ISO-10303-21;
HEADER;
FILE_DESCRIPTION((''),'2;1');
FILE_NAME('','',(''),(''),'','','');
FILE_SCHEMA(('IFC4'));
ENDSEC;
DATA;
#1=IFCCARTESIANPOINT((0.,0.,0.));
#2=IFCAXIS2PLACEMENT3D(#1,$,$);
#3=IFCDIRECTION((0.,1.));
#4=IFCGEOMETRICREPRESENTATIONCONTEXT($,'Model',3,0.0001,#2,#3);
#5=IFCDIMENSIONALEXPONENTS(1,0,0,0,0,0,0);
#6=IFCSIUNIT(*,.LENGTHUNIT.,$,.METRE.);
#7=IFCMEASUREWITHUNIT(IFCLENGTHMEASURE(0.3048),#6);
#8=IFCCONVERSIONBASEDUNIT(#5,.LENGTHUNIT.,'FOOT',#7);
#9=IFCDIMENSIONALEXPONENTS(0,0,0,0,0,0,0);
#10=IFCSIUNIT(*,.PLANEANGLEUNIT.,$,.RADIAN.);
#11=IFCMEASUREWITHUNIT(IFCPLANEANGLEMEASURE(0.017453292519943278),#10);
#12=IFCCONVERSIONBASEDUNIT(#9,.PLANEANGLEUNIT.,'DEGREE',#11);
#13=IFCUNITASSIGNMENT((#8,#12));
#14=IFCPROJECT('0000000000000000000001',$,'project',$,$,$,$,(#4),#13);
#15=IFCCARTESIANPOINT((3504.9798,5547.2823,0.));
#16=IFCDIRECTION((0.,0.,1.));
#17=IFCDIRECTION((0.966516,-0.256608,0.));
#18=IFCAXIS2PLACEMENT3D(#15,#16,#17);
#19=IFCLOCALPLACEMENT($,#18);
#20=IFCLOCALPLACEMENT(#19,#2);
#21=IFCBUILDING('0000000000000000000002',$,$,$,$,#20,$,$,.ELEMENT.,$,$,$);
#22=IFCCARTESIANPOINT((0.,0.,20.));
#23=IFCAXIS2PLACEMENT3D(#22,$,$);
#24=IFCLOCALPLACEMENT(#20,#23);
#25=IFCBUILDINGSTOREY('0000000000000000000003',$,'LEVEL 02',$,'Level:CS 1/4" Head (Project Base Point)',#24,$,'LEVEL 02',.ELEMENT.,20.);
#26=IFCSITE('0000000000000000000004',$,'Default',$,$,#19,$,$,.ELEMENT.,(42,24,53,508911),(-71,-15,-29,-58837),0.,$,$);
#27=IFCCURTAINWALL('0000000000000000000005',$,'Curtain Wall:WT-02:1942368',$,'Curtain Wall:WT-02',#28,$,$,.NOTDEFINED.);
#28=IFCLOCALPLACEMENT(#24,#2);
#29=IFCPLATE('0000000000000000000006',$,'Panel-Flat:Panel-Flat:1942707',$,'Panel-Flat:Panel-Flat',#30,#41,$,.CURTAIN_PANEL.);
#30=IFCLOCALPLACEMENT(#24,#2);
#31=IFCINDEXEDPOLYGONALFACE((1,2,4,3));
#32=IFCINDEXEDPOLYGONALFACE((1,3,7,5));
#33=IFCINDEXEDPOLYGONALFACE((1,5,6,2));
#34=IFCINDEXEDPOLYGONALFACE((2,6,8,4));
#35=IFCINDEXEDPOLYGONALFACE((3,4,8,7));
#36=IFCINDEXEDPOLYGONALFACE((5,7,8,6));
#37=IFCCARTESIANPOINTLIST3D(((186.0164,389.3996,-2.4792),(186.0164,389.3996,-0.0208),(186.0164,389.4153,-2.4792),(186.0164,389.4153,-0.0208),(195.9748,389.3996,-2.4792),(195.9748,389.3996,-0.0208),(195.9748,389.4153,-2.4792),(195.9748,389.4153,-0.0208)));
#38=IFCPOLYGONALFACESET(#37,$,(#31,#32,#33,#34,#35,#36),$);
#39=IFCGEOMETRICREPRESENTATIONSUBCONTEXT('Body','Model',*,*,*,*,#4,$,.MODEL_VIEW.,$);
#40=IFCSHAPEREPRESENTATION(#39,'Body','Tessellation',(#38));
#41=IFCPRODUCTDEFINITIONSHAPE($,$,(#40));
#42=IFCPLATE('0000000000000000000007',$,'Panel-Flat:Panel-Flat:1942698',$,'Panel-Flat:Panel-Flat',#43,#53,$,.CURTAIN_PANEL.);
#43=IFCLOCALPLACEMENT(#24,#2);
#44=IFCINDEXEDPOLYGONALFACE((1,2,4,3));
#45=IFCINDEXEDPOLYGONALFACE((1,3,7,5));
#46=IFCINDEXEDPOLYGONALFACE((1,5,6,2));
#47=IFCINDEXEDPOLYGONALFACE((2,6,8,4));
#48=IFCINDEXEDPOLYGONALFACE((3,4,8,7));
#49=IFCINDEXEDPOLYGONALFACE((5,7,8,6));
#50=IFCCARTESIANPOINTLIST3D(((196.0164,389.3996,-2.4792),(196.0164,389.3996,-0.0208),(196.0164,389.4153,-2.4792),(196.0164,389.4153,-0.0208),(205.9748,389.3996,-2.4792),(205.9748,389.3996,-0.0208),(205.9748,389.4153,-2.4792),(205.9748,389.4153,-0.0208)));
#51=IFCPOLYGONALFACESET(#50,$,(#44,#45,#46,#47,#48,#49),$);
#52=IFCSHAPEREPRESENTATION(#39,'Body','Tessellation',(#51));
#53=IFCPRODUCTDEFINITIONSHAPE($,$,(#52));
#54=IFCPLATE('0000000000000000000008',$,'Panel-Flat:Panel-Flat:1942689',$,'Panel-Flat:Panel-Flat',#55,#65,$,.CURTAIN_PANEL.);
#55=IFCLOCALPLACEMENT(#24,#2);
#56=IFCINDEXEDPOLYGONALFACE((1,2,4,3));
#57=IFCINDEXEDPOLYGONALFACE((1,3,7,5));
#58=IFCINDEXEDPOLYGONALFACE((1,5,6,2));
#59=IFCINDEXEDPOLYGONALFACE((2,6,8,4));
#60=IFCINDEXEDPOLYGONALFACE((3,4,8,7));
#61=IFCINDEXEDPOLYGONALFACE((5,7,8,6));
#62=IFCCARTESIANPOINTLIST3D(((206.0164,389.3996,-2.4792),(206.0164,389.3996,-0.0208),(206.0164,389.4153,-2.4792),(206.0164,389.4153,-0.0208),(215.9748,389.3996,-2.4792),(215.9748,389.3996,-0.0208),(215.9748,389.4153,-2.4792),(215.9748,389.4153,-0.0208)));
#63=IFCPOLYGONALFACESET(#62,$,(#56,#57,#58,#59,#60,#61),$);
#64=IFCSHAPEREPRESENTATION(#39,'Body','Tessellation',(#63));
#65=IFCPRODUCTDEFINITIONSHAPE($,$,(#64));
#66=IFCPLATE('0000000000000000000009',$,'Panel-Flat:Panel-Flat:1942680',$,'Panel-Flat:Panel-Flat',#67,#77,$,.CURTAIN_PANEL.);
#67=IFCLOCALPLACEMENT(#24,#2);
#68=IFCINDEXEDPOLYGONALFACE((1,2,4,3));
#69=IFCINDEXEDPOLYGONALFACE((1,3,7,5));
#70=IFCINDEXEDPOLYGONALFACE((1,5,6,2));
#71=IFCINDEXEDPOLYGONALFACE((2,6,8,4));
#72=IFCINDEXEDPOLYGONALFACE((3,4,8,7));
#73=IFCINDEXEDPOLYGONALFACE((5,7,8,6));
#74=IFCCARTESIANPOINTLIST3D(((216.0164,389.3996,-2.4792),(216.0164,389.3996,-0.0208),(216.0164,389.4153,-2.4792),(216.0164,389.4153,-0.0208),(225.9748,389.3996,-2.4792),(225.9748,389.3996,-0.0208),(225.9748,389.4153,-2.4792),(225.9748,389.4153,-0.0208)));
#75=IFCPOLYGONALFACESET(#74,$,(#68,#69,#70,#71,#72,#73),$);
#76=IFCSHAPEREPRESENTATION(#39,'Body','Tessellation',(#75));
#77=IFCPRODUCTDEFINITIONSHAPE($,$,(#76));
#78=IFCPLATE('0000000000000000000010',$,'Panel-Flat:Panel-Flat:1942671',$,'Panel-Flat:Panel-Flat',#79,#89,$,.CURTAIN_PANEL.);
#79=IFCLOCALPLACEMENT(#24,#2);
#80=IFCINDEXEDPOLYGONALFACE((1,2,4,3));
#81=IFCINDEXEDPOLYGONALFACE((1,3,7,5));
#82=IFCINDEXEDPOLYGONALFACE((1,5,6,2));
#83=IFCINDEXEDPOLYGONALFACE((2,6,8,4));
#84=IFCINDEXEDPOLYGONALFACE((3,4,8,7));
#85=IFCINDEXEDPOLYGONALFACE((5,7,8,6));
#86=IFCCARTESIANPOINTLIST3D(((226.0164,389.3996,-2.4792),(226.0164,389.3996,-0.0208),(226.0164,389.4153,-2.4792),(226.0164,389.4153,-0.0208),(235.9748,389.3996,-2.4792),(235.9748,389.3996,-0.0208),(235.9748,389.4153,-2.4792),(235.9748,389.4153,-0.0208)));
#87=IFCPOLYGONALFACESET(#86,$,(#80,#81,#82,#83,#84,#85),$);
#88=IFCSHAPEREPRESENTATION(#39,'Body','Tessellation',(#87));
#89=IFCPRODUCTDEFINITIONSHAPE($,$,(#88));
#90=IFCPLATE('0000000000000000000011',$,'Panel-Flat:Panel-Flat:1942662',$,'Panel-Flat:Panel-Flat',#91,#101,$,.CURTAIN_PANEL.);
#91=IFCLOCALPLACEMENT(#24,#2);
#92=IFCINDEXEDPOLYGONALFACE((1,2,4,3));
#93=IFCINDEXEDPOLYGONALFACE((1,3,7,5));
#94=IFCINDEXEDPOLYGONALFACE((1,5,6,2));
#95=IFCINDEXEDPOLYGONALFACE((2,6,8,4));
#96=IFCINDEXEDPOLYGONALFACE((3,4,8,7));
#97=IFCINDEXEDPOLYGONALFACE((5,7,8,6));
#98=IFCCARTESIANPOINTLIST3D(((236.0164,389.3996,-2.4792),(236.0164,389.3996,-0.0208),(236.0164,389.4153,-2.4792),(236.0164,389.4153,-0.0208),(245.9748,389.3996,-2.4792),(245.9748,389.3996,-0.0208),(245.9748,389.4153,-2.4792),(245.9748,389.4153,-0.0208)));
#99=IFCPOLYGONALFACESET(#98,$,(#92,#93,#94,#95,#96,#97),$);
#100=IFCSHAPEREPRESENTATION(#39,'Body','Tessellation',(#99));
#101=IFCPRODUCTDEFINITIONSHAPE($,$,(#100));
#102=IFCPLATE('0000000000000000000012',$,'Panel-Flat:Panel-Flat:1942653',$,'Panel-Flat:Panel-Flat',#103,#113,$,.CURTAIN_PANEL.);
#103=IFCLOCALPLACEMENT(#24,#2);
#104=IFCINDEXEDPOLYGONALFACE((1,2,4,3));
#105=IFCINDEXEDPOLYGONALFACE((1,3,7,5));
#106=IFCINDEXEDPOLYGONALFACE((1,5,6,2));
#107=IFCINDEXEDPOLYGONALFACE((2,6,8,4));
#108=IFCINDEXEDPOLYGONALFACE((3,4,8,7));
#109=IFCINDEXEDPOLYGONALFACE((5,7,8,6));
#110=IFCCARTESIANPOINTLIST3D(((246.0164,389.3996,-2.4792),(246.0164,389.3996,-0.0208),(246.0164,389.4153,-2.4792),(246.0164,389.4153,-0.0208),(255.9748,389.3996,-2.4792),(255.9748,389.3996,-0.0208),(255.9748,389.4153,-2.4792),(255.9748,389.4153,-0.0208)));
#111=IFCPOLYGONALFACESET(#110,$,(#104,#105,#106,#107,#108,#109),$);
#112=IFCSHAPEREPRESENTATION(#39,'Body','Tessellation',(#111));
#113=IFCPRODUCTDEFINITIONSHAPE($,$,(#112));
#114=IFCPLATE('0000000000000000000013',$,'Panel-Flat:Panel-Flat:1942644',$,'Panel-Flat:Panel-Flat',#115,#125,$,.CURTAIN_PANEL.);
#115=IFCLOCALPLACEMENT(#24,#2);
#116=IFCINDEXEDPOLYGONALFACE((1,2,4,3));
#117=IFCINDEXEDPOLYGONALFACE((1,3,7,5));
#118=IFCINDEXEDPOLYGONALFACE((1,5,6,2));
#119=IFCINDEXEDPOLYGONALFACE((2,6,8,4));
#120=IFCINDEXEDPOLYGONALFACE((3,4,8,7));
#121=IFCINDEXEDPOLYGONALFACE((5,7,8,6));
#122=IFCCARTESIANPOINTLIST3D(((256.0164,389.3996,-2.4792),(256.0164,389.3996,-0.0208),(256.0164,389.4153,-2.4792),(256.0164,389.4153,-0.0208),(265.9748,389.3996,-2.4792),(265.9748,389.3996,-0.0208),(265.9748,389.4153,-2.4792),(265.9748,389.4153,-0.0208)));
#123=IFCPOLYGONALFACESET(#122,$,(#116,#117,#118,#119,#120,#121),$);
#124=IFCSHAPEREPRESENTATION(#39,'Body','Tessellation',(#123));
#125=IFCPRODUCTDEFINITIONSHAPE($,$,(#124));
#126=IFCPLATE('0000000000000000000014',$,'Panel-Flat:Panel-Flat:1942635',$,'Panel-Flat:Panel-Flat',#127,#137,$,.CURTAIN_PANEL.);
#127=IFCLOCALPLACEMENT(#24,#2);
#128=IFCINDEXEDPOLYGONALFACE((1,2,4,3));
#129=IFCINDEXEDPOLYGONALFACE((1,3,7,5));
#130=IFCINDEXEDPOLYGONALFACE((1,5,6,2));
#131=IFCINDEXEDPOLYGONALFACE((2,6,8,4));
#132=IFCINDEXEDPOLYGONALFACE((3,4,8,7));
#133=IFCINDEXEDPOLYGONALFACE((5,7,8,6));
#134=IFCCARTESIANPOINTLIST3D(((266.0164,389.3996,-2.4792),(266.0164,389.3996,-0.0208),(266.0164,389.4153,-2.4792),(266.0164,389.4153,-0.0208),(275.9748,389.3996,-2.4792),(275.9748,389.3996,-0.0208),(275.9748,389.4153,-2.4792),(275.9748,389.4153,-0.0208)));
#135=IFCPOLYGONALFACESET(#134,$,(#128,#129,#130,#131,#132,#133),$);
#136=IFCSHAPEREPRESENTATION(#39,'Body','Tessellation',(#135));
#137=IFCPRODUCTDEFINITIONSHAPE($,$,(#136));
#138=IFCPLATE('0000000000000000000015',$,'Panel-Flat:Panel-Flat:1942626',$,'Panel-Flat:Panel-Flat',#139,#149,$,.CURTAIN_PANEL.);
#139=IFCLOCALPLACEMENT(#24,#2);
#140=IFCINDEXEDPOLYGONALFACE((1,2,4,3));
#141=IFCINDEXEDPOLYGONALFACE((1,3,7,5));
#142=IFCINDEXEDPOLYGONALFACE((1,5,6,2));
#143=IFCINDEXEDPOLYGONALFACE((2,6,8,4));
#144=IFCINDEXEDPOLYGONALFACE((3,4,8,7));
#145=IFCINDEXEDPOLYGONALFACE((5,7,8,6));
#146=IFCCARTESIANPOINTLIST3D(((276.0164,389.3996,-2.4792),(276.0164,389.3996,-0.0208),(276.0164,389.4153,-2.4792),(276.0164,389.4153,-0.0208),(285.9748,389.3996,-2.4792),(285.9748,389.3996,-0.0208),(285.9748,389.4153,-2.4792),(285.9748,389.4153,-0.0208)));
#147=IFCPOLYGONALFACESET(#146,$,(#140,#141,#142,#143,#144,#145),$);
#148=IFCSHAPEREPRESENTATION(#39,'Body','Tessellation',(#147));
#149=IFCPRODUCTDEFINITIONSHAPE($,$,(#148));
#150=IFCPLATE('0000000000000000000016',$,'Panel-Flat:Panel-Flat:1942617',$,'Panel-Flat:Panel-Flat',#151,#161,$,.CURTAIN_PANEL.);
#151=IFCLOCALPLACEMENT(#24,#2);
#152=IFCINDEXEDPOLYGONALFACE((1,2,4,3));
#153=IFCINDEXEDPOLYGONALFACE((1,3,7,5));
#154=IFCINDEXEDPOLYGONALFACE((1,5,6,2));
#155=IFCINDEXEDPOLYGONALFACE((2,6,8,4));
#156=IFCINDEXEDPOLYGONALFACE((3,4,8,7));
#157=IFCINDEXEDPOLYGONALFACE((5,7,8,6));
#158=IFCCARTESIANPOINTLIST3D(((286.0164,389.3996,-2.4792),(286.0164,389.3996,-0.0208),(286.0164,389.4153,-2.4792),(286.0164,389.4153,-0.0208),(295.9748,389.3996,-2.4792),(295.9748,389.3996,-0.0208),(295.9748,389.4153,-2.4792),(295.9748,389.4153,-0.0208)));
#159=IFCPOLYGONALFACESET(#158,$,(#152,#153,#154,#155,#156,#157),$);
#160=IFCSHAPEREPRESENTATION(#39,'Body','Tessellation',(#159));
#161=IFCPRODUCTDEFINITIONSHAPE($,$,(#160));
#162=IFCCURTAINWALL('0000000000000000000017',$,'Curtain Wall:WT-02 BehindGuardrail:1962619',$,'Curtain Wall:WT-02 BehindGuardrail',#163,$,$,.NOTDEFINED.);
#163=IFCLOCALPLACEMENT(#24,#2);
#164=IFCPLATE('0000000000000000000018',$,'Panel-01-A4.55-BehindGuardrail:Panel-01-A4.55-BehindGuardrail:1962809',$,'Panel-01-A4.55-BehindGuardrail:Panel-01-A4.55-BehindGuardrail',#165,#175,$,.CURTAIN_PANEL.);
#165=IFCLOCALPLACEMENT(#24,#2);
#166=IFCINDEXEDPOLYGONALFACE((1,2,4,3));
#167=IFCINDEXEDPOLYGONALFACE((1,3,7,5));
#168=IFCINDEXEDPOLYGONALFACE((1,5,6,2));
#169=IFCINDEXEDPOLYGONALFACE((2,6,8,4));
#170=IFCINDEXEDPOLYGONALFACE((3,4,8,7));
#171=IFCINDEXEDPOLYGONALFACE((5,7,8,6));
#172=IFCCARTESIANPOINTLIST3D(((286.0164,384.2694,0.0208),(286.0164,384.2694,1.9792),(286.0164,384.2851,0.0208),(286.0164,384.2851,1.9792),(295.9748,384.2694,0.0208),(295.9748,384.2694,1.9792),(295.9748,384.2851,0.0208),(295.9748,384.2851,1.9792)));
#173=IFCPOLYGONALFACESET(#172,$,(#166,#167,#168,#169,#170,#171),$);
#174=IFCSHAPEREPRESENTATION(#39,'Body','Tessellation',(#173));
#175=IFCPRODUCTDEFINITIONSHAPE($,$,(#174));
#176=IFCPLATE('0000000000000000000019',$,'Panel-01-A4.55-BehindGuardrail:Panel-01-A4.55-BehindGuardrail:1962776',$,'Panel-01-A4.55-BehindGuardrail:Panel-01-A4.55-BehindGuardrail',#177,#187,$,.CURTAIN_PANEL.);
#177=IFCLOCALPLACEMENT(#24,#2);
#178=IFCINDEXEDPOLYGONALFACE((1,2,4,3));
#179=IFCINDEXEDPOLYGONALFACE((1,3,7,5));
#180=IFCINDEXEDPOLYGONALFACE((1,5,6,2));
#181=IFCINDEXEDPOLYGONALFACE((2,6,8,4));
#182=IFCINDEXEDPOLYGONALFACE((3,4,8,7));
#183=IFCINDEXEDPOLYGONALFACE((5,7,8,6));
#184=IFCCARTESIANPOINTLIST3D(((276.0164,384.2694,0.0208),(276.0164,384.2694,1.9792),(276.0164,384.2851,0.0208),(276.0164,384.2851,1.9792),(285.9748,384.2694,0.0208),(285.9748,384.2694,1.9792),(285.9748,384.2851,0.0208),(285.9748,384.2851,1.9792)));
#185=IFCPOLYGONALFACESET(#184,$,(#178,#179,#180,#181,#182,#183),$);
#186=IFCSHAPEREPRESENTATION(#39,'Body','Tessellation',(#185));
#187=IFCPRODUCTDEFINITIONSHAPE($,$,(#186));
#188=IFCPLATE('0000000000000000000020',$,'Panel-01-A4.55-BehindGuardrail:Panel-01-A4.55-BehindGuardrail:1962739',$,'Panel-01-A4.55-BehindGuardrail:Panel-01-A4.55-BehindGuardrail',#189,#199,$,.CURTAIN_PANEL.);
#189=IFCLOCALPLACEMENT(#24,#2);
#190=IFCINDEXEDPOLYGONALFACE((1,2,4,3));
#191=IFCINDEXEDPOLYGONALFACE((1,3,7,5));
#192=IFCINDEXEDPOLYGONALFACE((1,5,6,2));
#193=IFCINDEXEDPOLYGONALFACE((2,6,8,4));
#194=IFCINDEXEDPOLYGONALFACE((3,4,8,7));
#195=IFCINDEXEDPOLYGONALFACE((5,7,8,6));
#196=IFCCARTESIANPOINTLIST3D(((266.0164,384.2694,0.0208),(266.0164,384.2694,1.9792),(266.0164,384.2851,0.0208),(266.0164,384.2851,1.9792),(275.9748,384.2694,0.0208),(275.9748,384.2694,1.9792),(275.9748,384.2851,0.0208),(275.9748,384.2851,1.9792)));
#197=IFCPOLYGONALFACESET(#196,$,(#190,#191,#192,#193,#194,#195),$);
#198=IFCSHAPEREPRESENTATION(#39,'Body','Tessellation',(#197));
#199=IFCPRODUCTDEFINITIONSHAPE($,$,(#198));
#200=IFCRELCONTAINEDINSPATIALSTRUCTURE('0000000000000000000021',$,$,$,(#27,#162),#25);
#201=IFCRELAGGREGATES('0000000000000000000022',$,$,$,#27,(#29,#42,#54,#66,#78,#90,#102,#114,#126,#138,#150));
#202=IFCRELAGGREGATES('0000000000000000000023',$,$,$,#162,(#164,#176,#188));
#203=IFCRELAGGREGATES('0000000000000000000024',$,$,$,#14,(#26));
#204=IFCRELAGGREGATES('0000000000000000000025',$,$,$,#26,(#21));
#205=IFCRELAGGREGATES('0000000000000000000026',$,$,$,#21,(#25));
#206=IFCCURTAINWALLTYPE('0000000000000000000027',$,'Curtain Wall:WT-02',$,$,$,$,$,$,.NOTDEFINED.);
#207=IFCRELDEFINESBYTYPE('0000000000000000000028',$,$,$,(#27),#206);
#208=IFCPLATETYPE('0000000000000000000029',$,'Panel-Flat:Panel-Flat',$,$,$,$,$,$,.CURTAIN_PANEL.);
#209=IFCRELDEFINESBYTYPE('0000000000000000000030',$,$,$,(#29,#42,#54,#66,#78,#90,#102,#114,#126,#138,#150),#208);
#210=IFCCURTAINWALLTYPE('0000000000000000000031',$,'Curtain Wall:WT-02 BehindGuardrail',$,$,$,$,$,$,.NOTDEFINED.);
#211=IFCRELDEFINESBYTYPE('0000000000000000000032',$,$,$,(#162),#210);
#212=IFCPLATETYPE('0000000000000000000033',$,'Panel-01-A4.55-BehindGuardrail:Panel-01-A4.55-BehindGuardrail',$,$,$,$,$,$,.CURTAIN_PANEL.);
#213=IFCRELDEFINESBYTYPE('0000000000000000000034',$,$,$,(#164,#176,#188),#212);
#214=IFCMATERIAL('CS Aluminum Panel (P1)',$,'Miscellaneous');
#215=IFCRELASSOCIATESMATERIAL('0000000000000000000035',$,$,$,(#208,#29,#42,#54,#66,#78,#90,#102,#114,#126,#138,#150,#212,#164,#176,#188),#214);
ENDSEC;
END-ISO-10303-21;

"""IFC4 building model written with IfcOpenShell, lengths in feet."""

from ifc_helpers import new_model, entity, si_unit, converted_unit, direction, frame, origin, place, context, subcontext, project, spatial, indexed_curve, outline, extrude, source, transform, mapped, material, type_object, type_shapes, element, aggregate, save


model = new_model("IFC4")

# Units and contexts
model_context = context("Model", 3, precision=0.0001, world=origin(), true_north=direction((0.0, 1.0)))
body_context = subcontext(model_context, "Body", "Model", "MODEL_VIEW")
ifc_project = project(units=[converted_unit("LENGTHUNIT", "FOOT", entity("IfcLengthMeasure", 0.3048), si_unit("LENGTHUNIT", "METRE"), dimensions=[1, 0, 0, 0, 0, 0, 0]), converted_unit("PLANEANGLEUNIT", "DEGREE", entity("IfcPlaneAngleMeasure", 0.017453292519943278), si_unit("PLANEANGLEUNIT", "RADIAN"), dimensions=[0, 0, 0, 0, 0, 0, 0])], contexts=[model_context])

# Site, building, storey
site_placement = place(None, frame((3504.9798, 5547.2823, 0.0), z_axis=(0.0, 0.0, 1.0), x_axis=(0.966516, -0.256608, 0.0)))
site = spatial("IfcSite", under=ifc_project, at=site_placement, Name="Default", CompositionType="ELEMENT", RefLatitude=(42, 24, 53, 508911), RefLongitude=(-71, -15, -29, -58837), RefElevation=0.0)
building_placement = place(site_placement, origin())
building = spatial("IfcBuilding", under=site, at=building_placement, CompositionType="ELEMENT")
storey_placement = place(building_placement, frame((0.0, 0.0, 20.0)))
storey = spatial("IfcBuildingStorey", under=building, at=storey_placement, Name="LEVEL 02", ObjectType="Level:CS 1/4\" Head (Project Base Point)", LongName="LEVEL 02", CompositionType="ELEMENT", Elevation=20.0)

# Curtain walls, plates
curtain_wall_type_1 = type_object("IfcCurtainWallType", Name="Curtain Wall:WT-02", PredefinedType="NOTDEFINED")
curtain_wall_1_placement = place(storey_placement, frame((0.0, 0.0, -20.0)))
curtain_wall_1 = element("IfcCurtainWall", 1, at=curtain_wall_1_placement, inside=storey, type_object=curtain_wall_type_1, Name="Curtain Wall:WT-02:1942368", ObjectType="Curtain Wall:WT-02", PredefinedType="NOTDEFINED")
ifc_material_1 = material(Name="CS Aluminum Panel (P1)", Category="Miscellaneous")
plate_type_1 = type_object("IfcPlateType", Name="Panel-Flat:Panel-Flat", PredefinedType="CURTAIN_PANEL", material=ifc_material_1)
shared_shape_1 = source(origin(), body_context, "Body", "SweptSolid", [
    extrude(outline(indexed_curve([(-0.0078, -4.9792), (0.0078, -4.9792), (0.0078, 4.9792), (-0.0078, 4.9792), (-0.0078, -4.9792)], self_intersect=False)), frame((0.0, -0.0078, 0.0208), z_axis=(0.0, 0.0, 1.0), x_axis=(0.0, -1.0, 0.0)), (0.0, 0.0, 1.0), 2.4583),
])
type_shapes(plate_type_1, [shared_shape_1])
plate_1_placement = place(curtain_wall_1_placement, frame((190.9956, 389.4153, 17.5)))
plate_1 = element("IfcPlate", 2, at=plate_1_placement, type_object=plate_type_1, material=ifc_material_1, Name="Panel-Flat:Panel-Flat:1942707", ObjectType="Panel-Flat:Panel-Flat", PredefinedType="CURTAIN_PANEL", context=body_context, shape_type="MappedRepresentation", body=[
    mapped(shared_shape_1, transform((0.0, 0.0, 0.0), scale=1.0)),
])
plate_2_placement = place(curtain_wall_1_placement, frame((200.9956, 389.4153, 17.5)))
plate_2 = element("IfcPlate", 3, at=plate_2_placement, type_object=plate_type_1, material=ifc_material_1, Name="Panel-Flat:Panel-Flat:1942698", ObjectType="Panel-Flat:Panel-Flat", PredefinedType="CURTAIN_PANEL", context=body_context, shape_type="MappedRepresentation", body=[
    mapped(shared_shape_1, transform((0.0, 0.0, 0.0), scale=1.0)),
])
plate_3_placement = place(curtain_wall_1_placement, frame((210.9956, 389.4153, 17.5)))
plate_3 = element("IfcPlate", 4, at=plate_3_placement, type_object=plate_type_1, material=ifc_material_1, Name="Panel-Flat:Panel-Flat:1942689", ObjectType="Panel-Flat:Panel-Flat", PredefinedType="CURTAIN_PANEL", context=body_context, shape_type="MappedRepresentation", body=[
    mapped(shared_shape_1, transform((0.0, 0.0, 0.0), scale=1.0)),
])
plate_4_placement = place(curtain_wall_1_placement, frame((220.9956, 389.4153, 17.5)))
plate_4 = element("IfcPlate", 5, at=plate_4_placement, type_object=plate_type_1, material=ifc_material_1, Name="Panel-Flat:Panel-Flat:1942680", ObjectType="Panel-Flat:Panel-Flat", PredefinedType="CURTAIN_PANEL", context=body_context, shape_type="MappedRepresentation", body=[
    mapped(shared_shape_1, transform((0.0, 0.0, 0.0), scale=1.0)),
])
plate_5_placement = place(curtain_wall_1_placement, frame((230.9956, 389.4153, 17.5)))
plate_5 = element("IfcPlate", 6, at=plate_5_placement, type_object=plate_type_1, material=ifc_material_1, Name="Panel-Flat:Panel-Flat:1942671", ObjectType="Panel-Flat:Panel-Flat", PredefinedType="CURTAIN_PANEL", context=body_context, shape_type="MappedRepresentation", body=[
    mapped(shared_shape_1, transform((0.0, 0.0, 0.0), scale=1.0)),
])
plate_6_placement = place(curtain_wall_1_placement, frame((240.9956, 389.4153, 17.5)))
plate_6 = element("IfcPlate", 7, at=plate_6_placement, type_object=plate_type_1, material=ifc_material_1, Name="Panel-Flat:Panel-Flat:1942662", ObjectType="Panel-Flat:Panel-Flat", PredefinedType="CURTAIN_PANEL", context=body_context, shape_type="MappedRepresentation", body=[
    mapped(shared_shape_1, transform((0.0, 0.0, 0.0), scale=1.0)),
])
plate_7_placement = place(curtain_wall_1_placement, frame((250.9956, 389.4153, 17.5)))
plate_7 = element("IfcPlate", 8, at=plate_7_placement, type_object=plate_type_1, material=ifc_material_1, Name="Panel-Flat:Panel-Flat:1942653", ObjectType="Panel-Flat:Panel-Flat", PredefinedType="CURTAIN_PANEL", context=body_context, shape_type="MappedRepresentation", body=[
    mapped(shared_shape_1, transform((0.0, 0.0, 0.0), scale=1.0)),
])
plate_8_placement = place(curtain_wall_1_placement, frame((260.9956, 389.4153, 17.5)))
plate_8 = element("IfcPlate", 9, at=plate_8_placement, type_object=plate_type_1, material=ifc_material_1, Name="Panel-Flat:Panel-Flat:1942644", ObjectType="Panel-Flat:Panel-Flat", PredefinedType="CURTAIN_PANEL", context=body_context, shape_type="MappedRepresentation", body=[
    mapped(shared_shape_1, transform((0.0, 0.0, 0.0), scale=1.0)),
])
plate_9_placement = place(curtain_wall_1_placement, frame((270.9956, 389.4153, 17.5)))
plate_9 = element("IfcPlate", 10, at=plate_9_placement, type_object=plate_type_1, material=ifc_material_1, Name="Panel-Flat:Panel-Flat:1942635", ObjectType="Panel-Flat:Panel-Flat", PredefinedType="CURTAIN_PANEL", context=body_context, shape_type="MappedRepresentation", body=[
    mapped(shared_shape_1, transform((0.0, 0.0, 0.0), scale=1.0)),
])
plate_10_placement = place(curtain_wall_1_placement, frame((280.9956, 389.4153, 17.5)))
plate_10 = element("IfcPlate", 11, at=plate_10_placement, type_object=plate_type_1, material=ifc_material_1, Name="Panel-Flat:Panel-Flat:1942626", ObjectType="Panel-Flat:Panel-Flat", PredefinedType="CURTAIN_PANEL", context=body_context, shape_type="MappedRepresentation", body=[
    mapped(shared_shape_1, transform((0.0, 0.0, 0.0), scale=1.0)),
])
plate_11_placement = place(curtain_wall_1_placement, frame((290.9956, 389.4153, 17.5)))
plate_11 = element("IfcPlate", 12, at=plate_11_placement, type_object=plate_type_1, material=ifc_material_1, Name="Panel-Flat:Panel-Flat:1942617", ObjectType="Panel-Flat:Panel-Flat", PredefinedType="CURTAIN_PANEL", context=body_context, shape_type="MappedRepresentation", body=[
    mapped(shared_shape_1, transform((0.0, 0.0, 0.0), scale=1.0)),
])
aggregate(curtain_wall_1, [plate_1, plate_2, plate_3, plate_4, plate_5, plate_6, plate_7, plate_8, plate_9, plate_10, plate_11])
curtain_wall_type_2 = type_object("IfcCurtainWallType", Name="Curtain Wall:WT-02 BehindGuardrail", PredefinedType="NOTDEFINED")
curtain_wall_2_placement = place(storey_placement, frame((0.0, 0.0, -20.0)))
curtain_wall_2 = element("IfcCurtainWall", 13, at=curtain_wall_2_placement, inside=storey, type_object=curtain_wall_type_2, Name="Curtain Wall:WT-02 BehindGuardrail:1962619", ObjectType="Curtain Wall:WT-02 BehindGuardrail", PredefinedType="NOTDEFINED")
plate_type_2 = type_object("IfcPlateType", Name="Panel-01-A4.55-BehindGuardrail:Panel-01-A4.55-BehindGuardrail", PredefinedType="CURTAIN_PANEL", material=ifc_material_1)
shared_shape_2 = source(origin(), body_context, "Body", "SweptSolid", [
    extrude(outline(indexed_curve([(-0.0078, -4.9792), (0.0078, -4.9792), (0.0078, 4.9792), (-0.0078, 4.9792), (-0.0078, -4.9792)], self_intersect=False)), frame((0.0, -0.0078, 0.0208), z_axis=(0.0, 0.0, 1.0), x_axis=(0.0, -1.0, 0.0)), (0.0, 0.0, 1.0), 1.9583),
])
type_shapes(plate_type_2, [shared_shape_2])
plate_12_placement = place(curtain_wall_2_placement, frame((290.9956, 384.2694, 20.0), z_axis=(0.0, 0.0, 1.0), x_axis=(-1.0, 0.0, 0.0)))
plate_12 = element("IfcPlate", 14, at=plate_12_placement, type_object=plate_type_2, material=ifc_material_1, Name="Panel-01-A4.55-BehindGuardrail:Panel-01-A4.55-BehindGuardrail:1962809", ObjectType="Panel-01-A4.55-BehindGuardrail:Panel-01-A4.55-BehindGuardrail", PredefinedType="CURTAIN_PANEL", context=body_context, shape_type="MappedRepresentation", body=[
    mapped(shared_shape_2, transform((0.0, 0.0, 0.0), scale=1.0)),
])
plate_13_placement = place(curtain_wall_2_placement, frame((280.9956, 384.2694, 20.0), z_axis=(0.0, 0.0, 1.0), x_axis=(-1.0, 0.0, 0.0)))
plate_13 = element("IfcPlate", 15, at=plate_13_placement, type_object=plate_type_2, material=ifc_material_1, Name="Panel-01-A4.55-BehindGuardrail:Panel-01-A4.55-BehindGuardrail:1962776", ObjectType="Panel-01-A4.55-BehindGuardrail:Panel-01-A4.55-BehindGuardrail", PredefinedType="CURTAIN_PANEL", context=body_context, shape_type="MappedRepresentation", body=[
    mapped(shared_shape_2, transform((0.0, 0.0, 0.0), scale=1.0)),
])
plate_14_placement = place(curtain_wall_2_placement, frame((270.9956, 384.2694, 20.0), z_axis=(0.0, 0.0, 1.0), x_axis=(-1.0, 0.0, 0.0)))
plate_14 = element("IfcPlate", 16, at=plate_14_placement, type_object=plate_type_2, material=ifc_material_1, Name="Panel-01-A4.55-BehindGuardrail:Panel-01-A4.55-BehindGuardrail:1962739", ObjectType="Panel-01-A4.55-BehindGuardrail:Panel-01-A4.55-BehindGuardrail", PredefinedType="CURTAIN_PANEL", context=body_context, shape_type="MappedRepresentation", body=[
    mapped(shared_shape_2, transform((0.0, 0.0, 0.0), scale=1.0)),
])

aggregate(curtain_wall_2, [plate_12, plate_13, plate_14])

save(model, "model.ifc")
